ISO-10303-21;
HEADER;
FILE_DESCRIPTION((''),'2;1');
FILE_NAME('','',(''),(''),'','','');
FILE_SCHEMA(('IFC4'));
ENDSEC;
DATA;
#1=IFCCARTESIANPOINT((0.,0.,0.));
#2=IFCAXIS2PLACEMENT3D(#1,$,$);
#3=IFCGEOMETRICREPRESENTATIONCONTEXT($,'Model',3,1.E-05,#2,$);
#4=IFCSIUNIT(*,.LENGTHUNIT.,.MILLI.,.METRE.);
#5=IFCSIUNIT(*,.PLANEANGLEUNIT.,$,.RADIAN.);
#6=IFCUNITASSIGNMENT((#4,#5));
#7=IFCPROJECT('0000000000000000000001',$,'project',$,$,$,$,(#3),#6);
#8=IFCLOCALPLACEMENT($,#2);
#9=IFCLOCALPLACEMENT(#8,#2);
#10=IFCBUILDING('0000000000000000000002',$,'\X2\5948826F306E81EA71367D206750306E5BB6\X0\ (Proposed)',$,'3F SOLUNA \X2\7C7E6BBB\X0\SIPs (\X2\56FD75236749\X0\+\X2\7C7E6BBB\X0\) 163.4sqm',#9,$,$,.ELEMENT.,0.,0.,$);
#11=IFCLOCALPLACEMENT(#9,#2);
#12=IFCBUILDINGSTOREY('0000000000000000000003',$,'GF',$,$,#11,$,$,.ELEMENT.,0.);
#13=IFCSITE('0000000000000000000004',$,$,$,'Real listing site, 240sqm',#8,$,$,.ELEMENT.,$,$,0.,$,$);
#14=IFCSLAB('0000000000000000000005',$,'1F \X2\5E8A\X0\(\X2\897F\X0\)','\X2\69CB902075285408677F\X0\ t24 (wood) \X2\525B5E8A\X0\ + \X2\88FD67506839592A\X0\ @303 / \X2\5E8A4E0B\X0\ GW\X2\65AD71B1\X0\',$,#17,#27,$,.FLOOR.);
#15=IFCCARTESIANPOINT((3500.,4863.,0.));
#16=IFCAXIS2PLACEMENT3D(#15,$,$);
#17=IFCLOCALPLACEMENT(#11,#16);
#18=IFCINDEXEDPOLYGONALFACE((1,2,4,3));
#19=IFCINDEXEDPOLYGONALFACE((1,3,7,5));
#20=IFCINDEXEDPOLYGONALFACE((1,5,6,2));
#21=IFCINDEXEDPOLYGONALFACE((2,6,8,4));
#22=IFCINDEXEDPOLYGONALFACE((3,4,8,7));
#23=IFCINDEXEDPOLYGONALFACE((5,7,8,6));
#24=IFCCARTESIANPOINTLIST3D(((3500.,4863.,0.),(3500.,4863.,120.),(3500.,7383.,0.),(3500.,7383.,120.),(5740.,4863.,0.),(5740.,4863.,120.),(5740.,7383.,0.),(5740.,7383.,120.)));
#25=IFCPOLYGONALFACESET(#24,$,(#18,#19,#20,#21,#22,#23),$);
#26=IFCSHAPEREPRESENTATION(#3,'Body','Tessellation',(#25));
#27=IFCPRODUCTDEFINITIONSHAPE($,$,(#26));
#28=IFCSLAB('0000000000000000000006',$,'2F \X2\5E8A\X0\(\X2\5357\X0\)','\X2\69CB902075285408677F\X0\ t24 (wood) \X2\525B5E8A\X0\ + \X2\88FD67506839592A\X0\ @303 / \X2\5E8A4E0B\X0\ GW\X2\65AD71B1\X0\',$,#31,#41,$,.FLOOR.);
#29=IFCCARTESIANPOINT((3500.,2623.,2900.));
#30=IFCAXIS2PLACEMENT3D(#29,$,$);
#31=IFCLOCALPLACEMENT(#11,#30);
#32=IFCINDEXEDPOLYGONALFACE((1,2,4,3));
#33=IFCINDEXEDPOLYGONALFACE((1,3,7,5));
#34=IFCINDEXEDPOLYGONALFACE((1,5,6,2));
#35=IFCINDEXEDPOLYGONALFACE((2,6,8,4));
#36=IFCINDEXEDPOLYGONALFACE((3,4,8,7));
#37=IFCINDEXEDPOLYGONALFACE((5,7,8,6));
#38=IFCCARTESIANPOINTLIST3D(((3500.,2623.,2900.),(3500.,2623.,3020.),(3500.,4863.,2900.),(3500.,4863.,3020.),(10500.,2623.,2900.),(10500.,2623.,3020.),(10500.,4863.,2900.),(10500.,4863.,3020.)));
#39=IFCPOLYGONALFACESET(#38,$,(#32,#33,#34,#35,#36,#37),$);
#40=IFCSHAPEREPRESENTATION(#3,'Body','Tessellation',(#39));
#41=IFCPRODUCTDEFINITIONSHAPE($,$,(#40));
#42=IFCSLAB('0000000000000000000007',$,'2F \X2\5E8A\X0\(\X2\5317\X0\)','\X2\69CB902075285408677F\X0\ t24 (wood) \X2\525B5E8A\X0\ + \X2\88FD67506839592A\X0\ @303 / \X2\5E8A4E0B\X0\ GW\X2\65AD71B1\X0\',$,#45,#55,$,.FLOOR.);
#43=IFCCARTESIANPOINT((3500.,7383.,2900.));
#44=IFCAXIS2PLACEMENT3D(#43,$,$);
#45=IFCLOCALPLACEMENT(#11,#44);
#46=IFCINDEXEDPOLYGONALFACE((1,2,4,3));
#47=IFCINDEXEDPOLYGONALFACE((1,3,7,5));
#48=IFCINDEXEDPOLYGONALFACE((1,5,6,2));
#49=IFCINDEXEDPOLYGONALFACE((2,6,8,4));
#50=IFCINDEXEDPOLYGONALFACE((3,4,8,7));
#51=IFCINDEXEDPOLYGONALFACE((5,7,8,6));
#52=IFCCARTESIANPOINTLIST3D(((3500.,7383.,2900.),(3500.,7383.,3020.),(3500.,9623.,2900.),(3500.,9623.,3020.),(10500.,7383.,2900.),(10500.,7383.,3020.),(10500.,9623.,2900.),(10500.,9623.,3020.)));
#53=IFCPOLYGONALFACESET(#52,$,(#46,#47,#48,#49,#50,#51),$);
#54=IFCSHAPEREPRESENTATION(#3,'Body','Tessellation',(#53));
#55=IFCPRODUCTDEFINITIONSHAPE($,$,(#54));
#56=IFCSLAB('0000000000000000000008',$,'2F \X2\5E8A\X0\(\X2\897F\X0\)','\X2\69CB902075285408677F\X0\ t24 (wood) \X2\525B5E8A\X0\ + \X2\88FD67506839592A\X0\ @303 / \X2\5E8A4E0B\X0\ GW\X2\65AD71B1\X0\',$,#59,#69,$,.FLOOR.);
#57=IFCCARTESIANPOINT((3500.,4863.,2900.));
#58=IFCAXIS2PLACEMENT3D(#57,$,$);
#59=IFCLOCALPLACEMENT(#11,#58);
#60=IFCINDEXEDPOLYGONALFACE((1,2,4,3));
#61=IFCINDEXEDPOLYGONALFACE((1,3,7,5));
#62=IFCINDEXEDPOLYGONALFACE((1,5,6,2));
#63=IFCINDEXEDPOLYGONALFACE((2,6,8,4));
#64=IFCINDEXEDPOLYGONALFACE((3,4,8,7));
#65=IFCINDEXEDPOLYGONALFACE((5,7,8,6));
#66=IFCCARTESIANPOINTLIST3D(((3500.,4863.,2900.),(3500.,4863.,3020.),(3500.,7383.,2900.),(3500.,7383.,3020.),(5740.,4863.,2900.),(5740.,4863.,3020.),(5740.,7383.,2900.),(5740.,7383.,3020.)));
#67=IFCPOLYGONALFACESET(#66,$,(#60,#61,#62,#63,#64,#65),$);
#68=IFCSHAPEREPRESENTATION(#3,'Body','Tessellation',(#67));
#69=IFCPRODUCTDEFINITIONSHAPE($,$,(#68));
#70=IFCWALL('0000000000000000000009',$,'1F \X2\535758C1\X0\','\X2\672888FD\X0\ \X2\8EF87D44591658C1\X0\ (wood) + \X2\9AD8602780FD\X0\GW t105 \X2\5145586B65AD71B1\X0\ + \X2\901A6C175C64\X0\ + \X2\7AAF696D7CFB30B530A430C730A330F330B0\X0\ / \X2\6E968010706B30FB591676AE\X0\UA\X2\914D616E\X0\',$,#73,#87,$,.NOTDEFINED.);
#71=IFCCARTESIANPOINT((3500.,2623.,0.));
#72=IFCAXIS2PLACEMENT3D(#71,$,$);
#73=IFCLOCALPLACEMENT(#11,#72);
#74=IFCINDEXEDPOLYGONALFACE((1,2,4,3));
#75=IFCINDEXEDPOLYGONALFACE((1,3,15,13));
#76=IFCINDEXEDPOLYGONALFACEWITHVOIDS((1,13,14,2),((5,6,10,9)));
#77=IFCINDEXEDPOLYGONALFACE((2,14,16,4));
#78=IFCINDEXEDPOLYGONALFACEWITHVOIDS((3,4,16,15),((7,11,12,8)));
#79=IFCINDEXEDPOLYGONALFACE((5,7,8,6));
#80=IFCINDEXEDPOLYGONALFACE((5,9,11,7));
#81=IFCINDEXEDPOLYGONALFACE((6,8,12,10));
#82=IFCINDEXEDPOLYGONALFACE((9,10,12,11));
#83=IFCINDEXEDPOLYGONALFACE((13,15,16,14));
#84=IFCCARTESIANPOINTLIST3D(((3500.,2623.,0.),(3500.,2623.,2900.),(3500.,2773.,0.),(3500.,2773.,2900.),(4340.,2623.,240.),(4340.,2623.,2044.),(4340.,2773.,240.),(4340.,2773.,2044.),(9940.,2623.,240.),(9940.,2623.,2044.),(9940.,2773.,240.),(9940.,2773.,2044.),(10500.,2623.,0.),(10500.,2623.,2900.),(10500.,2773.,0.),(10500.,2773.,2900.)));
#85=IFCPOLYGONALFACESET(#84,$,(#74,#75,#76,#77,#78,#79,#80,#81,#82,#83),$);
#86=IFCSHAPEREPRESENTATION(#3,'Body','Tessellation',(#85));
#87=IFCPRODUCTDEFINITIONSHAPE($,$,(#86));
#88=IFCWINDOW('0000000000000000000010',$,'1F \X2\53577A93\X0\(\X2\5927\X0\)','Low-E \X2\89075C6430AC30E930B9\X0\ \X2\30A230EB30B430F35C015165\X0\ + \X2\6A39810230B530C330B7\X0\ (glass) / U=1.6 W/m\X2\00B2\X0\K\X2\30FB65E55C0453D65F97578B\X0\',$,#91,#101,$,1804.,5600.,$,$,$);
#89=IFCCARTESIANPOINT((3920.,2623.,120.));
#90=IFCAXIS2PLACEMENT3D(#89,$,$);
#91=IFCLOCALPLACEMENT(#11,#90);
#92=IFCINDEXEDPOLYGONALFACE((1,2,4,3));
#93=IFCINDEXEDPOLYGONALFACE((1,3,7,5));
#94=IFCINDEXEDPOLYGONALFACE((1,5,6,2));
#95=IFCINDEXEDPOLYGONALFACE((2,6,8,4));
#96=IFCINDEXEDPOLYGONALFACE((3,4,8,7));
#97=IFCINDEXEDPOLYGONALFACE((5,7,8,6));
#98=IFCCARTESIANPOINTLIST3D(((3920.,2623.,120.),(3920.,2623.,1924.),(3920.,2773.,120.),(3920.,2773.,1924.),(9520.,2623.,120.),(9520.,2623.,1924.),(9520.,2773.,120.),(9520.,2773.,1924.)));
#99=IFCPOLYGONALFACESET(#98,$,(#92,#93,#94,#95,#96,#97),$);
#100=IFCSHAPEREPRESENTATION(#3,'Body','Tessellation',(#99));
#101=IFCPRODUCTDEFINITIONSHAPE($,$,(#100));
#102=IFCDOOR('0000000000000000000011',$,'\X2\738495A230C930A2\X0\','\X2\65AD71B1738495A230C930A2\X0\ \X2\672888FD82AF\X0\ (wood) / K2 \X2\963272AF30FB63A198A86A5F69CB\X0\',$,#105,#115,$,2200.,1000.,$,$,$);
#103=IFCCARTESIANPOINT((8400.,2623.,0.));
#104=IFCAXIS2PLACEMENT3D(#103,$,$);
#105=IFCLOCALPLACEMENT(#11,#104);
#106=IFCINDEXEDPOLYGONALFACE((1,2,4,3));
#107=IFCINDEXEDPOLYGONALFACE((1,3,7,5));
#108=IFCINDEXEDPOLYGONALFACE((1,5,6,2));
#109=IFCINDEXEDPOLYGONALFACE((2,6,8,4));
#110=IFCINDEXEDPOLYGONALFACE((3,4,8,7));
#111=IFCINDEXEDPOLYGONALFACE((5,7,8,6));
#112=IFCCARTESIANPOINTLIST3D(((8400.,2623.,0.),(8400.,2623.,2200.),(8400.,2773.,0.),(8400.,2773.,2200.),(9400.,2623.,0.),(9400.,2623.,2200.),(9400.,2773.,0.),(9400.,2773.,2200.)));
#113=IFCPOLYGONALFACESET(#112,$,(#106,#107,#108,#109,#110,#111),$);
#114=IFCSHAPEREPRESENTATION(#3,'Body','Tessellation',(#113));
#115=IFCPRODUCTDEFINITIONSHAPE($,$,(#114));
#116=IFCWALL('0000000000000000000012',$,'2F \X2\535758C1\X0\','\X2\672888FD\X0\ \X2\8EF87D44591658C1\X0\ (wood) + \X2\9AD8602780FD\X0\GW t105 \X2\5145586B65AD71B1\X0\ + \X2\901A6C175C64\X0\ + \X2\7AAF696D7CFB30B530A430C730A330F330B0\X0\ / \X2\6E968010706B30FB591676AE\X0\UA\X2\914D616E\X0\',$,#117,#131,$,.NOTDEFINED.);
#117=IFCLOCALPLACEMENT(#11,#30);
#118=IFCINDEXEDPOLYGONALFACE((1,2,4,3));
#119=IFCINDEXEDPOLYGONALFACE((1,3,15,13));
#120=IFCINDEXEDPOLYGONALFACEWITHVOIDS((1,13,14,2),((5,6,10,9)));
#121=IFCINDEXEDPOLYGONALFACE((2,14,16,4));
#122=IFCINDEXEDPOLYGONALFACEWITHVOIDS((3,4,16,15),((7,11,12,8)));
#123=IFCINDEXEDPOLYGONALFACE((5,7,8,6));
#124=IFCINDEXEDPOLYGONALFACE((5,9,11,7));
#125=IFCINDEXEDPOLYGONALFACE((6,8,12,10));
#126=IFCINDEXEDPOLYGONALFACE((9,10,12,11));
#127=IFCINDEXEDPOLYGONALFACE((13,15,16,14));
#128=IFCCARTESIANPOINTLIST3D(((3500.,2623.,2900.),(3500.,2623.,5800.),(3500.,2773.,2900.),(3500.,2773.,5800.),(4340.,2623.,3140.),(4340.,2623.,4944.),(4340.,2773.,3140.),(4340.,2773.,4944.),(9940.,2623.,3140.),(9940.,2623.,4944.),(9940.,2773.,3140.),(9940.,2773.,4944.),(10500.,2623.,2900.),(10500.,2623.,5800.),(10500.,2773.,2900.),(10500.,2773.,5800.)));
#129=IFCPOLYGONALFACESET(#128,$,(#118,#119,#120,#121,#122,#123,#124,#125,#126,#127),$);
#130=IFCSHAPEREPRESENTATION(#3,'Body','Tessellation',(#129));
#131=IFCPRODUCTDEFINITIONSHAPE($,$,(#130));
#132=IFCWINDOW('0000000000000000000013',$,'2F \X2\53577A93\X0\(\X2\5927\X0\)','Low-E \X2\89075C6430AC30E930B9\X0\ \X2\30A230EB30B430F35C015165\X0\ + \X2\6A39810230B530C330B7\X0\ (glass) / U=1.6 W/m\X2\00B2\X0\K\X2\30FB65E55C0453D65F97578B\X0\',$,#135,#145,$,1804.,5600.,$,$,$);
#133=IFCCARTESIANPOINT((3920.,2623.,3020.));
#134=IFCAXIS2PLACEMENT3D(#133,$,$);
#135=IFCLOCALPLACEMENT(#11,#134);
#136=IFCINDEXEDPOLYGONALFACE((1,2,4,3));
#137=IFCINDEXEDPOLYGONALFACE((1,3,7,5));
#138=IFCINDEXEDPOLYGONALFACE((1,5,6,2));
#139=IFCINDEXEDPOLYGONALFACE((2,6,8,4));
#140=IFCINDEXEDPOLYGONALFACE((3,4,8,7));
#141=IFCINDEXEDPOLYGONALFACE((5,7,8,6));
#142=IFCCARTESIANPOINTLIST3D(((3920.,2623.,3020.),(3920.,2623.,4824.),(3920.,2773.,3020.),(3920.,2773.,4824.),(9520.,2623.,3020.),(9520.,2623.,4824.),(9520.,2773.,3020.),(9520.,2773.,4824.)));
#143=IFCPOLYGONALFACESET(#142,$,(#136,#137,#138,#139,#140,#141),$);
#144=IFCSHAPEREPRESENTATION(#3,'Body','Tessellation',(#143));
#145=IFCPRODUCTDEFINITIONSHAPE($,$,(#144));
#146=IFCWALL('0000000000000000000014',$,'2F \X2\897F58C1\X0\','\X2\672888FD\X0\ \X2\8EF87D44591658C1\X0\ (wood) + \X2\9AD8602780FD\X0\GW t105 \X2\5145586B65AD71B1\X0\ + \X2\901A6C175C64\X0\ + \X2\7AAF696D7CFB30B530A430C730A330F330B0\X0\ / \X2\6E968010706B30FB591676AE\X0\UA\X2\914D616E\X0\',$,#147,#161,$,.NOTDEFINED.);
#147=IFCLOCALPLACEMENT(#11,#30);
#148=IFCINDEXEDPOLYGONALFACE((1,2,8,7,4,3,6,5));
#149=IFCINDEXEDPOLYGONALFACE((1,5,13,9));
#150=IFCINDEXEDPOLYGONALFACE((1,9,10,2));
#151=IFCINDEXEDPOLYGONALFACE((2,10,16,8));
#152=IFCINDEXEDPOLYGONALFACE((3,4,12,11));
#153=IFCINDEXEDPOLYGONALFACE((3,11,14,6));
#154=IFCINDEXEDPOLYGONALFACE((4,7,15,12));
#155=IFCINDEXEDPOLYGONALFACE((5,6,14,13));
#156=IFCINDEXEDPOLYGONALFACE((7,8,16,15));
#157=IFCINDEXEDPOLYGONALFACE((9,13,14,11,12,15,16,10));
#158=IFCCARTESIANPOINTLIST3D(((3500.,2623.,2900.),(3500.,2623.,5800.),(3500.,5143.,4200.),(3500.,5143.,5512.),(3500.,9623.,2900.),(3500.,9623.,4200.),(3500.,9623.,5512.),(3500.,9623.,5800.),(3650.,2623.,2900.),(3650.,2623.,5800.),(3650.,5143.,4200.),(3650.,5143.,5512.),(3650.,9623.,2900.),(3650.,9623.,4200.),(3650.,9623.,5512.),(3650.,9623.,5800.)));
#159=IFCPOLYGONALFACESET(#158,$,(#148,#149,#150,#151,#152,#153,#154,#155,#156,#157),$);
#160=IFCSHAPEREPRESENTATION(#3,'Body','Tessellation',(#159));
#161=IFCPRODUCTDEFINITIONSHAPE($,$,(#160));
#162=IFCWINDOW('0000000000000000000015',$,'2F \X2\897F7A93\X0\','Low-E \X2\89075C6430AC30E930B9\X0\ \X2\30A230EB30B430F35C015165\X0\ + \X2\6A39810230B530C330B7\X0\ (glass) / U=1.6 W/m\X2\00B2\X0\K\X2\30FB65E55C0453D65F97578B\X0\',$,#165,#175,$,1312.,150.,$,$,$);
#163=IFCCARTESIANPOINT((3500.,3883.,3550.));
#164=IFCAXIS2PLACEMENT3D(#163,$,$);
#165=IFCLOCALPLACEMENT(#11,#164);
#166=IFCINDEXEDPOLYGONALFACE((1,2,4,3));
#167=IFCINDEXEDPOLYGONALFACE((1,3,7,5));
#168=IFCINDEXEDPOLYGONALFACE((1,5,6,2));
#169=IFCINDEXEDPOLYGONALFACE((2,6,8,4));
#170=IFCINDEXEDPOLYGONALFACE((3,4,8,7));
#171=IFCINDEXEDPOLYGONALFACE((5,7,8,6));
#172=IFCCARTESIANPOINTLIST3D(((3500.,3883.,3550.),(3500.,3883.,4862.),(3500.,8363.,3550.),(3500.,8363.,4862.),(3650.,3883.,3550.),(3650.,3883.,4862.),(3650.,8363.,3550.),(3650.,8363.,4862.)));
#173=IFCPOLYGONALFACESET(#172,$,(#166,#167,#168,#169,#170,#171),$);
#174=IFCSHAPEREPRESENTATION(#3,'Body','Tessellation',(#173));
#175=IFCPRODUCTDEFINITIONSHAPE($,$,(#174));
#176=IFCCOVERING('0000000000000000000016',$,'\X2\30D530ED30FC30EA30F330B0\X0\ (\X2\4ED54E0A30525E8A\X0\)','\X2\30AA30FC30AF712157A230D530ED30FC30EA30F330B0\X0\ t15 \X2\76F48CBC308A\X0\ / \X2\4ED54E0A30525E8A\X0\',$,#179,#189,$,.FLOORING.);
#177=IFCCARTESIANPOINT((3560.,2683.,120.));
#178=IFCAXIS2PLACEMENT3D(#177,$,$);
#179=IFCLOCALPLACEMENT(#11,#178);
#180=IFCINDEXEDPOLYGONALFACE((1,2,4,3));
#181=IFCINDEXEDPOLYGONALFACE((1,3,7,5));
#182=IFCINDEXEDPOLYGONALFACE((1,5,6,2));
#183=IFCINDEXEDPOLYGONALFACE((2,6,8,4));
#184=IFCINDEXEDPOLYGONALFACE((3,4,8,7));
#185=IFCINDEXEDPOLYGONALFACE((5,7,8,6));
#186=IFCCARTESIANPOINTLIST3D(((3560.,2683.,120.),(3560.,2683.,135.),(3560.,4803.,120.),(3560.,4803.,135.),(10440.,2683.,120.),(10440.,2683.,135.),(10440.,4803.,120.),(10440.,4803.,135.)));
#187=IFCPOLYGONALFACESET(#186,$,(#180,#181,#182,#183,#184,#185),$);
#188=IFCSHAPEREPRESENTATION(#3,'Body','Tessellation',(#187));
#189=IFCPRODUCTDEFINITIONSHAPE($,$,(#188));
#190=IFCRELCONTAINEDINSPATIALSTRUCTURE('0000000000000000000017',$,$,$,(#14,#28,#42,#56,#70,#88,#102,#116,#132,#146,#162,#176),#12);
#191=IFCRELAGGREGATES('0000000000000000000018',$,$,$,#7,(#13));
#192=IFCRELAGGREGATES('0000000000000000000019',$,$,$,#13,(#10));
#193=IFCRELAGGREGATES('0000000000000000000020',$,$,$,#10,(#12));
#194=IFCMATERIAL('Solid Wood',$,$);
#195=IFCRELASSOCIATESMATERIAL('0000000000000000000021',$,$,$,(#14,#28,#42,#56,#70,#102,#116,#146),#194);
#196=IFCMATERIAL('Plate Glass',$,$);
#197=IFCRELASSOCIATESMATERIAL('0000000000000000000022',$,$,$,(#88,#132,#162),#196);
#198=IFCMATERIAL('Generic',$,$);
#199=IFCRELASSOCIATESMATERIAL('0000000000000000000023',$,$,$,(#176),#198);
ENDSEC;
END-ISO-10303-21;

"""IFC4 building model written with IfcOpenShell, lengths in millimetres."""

from ifc_helpers import new_model, si_unit, frame, frame_2d, origin, place, context, project, spatial, rectangle, extrude, material, element, fill, save


model = new_model("IFC4")

# Units and contexts
model_context = context("Model", 3, precision=1e-05, world=origin())
ifc_project = project(units=[si_unit("LENGTHUNIT", "METRE", prefix="MILLI"), si_unit("PLANEANGLEUNIT", "RADIAN")], contexts=[model_context])

# Site, building, storey
site_placement = place(None, origin())
site = spatial("IfcSite", under=ifc_project, at=site_placement, ObjectType="Real listing site, 240sqm", CompositionType="ELEMENT", RefElevation=0.0)
building_placement = place(site_placement, origin())
building = spatial("IfcBuilding", under=site, at=building_placement, Name="奈良の自然素材の家 (Proposed)", ObjectType="3F SOLUNA 籾殻SIPs (国産杉+籾殻) 163.4sqm", CompositionType="ELEMENT", ElevationOfRefHeight=0.0, ElevationOfTerrain=0.0)
storey_placement = place(building_placement, origin())
storey = spatial("IfcBuildingStorey", under=building, at=storey_placement, Name="GF", CompositionType="ELEMENT", Elevation=0.0)

# Slabs
ifc_material_1 = material(Name="Solid Wood")
slab_1_placement = place(storey_placement, frame((3500.0, 4863.0, 0.0)))
element("IfcSlab", 1, at=slab_1_placement, inside=storey, material=ifc_material_1, Name="1F 床(西)", Description="構造用合板 t24 (wood) 剛床 + 製材根太 @303 / 床下 GW断熱", PredefinedType="FLOOR", context=model_context, shape_type="SweptSolid", body=[
    extrude(rectangle(XDim=2240.0, YDim=2520.0, at=frame_2d((1120.0, 1260.0))), frame((3500.0, 4863.0, 0.0)), (0.0, 0.0, 1.0), 120.0),
])
slab_2_placement = place(storey_placement, frame((3500.0, 2623.0, 2900.0)))
element("IfcSlab", 2, at=slab_2_placement, inside=storey, material=ifc_material_1, Name="2F 床(南)", Description="構造用合板 t24 (wood) 剛床 + 製材根太 @303 / 床下 GW断熱", PredefinedType="FLOOR", context=model_context, shape_type="SweptSolid", body=[
    extrude(rectangle(XDim=7000.0, YDim=2240.0, at=frame_2d((3500.0, 1120.0))), frame((3500.0, 2623.0, 2900.0)), (0.0, 0.0, 1.0), 120.0),
])
slab_3_placement = place(storey_placement, frame((3500.0, 7383.0, 2900.0)))
element("IfcSlab", 3, at=slab_3_placement, inside=storey, material=ifc_material_1, Name="2F 床(北)", Description="構造用合板 t24 (wood) 剛床 + 製材根太 @303 / 床下 GW断熱", PredefinedType="FLOOR", context=model_context, shape_type="SweptSolid", body=[
    extrude(rectangle(XDim=7000.0, YDim=2240.0, at=frame_2d((3500.0, 1120.0))), frame((3500.0, 7383.0, 2900.0)), (0.0, 0.0, 1.0), 120.0),
])
slab_4_placement = place(storey_placement, frame((3500.0, 4863.0, 2900.0)))
element("IfcSlab", 4, at=slab_4_placement, inside=storey, material=ifc_material_1, Name="2F 床(西)", Description="構造用合板 t24 (wood) 剛床 + 製材根太 @303 / 床下 GW断熱", PredefinedType="FLOOR", context=model_context, shape_type="SweptSolid", body=[
    extrude(rectangle(XDim=2240.0, YDim=2520.0, at=frame_2d((1120.0, 1260.0))), frame((3500.0, 4863.0, 2900.0)), (0.0, 0.0, 1.0), 120.0),
])

# Wall, openings, window, door
wall_1_placement = place(storey_placement, frame((3500.0, 2623.0, 0.0)))
wall_1 = element("IfcWall", 5, at=wall_1_placement, inside=storey, material=ifc_material_1, Name="1F 南壁", Description="木製 軸組外壁 (wood) + 高性能GW t105 充填断熱 + 通気層 + 窯業系サイディング / 準耐火・外皮UA配慮", PredefinedType="NOTDEFINED", context=model_context, shape_type="SweptSolid", body=[
    extrude(rectangle(XDim=7000.0, YDim=150.0, at=frame_2d((3500.0, 75.0))), frame((3500.0, 2623.0, 0.0)), (0.0, 0.0, 1.0), 2900.0),
])
opening_1_placement = place(storey_placement, frame((3920.0, 2623.0, 120.0)))
opening_1 = element("IfcOpeningElement", 6, at=opening_1_placement, cuts=wall_1, PredefinedType="NOTDEFINED", context=model_context, shape_type="SweptSolid", body=[
    extrude(rectangle(XDim=5600.0, YDim=150.0, at=frame_2d((2800.0, 75.0))), frame((3920.0, 2623.0, 120.0)), (0.0, 0.0, 1.0), 1804.0),
])
opening_2_placement = place(storey_placement, frame((8400.0, 2623.0, 0.0)))
opening_2 = element("IfcOpeningElement", 7, at=opening_2_placement, cuts=wall_1, PredefinedType="NOTDEFINED", context=model_context, shape_type="SweptSolid", body=[
    extrude(rectangle(XDim=1000.0, YDim=150.0, at=frame_2d((500.0, 75.0))), frame((8400.0, 2623.0, 0.0)), (0.0, 0.0, 1.0), 2200.0),
])
ifc_material_2 = material(Name="Plate Glass")
window_1_placement = place(storey_placement, frame((3920.0, 2623.0, 120.0)))
window_1 = element("IfcWindow", 8, at=window_1_placement, inside=storey, material=ifc_material_2, Name="1F 南窓(大)", Description="Low-E 複層ガラス アルゴン封入 + 樹脂サッシ (glass) / U=1.6 W/m²K・日射取得型", OverallHeight=1804.0, OverallWidth=5600.0, context=model_context, shape_type="SweptSolid", body=[
    extrude(rectangle(XDim=5600.0, YDim=150.0, at=frame_2d((2800.0, 75.0))), frame((3920.0, 2623.0, 120.0)), (0.0, 0.0, 1.0), 1804.0),
])
fill(opening_1, window_1)
door_placement = place(storey_placement, frame((8400.0, 2623.0, 0.0)))
door = element("IfcDoor", 9, at=door_placement, inside=storey, material=ifc_material_1, Name="玄関ドア", Description="断熱玄関ドア 木製芯 (wood) / K2 防犯・採風機構", OverallHeight=2200.0, OverallWidth=1000.0, context=model_context, shape_type="SweptSolid", body=[
    extrude(rectangle(XDim=1000.0, YDim=150.0, at=frame_2d((500.0, 75.0))), frame((8400.0, 2623.0, 0.0)), (0.0, 0.0, 1.0), 2200.0),
])
fill(opening_2, door)

# Wall, opening, window
wall_2_placement = place(storey_placement, frame((3500.0, 2623.0, 2900.0)))
wall_2 = element("IfcWall", 10, at=wall_2_placement, inside=storey, material=ifc_material_1, Name="2F 南壁", Description="木製 軸組外壁 (wood) + 高性能GW t105 充填断熱 + 通気層 + 窯業系サイディング / 準耐火・外皮UA配慮", PredefinedType="NOTDEFINED", context=model_context, shape_type="SweptSolid", body=[
    extrude(rectangle(XDim=7000.0, YDim=150.0, at=frame_2d((3500.0, 75.0))), frame((3500.0, 2623.0, 2900.0)), (0.0, 0.0, 1.0), 2900.0),
])
opening_3_placement = place(storey_placement, frame((3920.0, 2623.0, 3020.0)))
opening_3 = element("IfcOpeningElement", 11, at=opening_3_placement, cuts=wall_2, PredefinedType="NOTDEFINED", context=model_context, shape_type="SweptSolid", body=[
    extrude(rectangle(XDim=5600.0, YDim=150.0, at=frame_2d((2800.0, 75.0))), frame((3920.0, 2623.0, 3020.0)), (0.0, 0.0, 1.0), 1804.0),
])
window_2_placement = place(storey_placement, frame((3920.0, 2623.0, 3020.0)))
window_2 = element("IfcWindow", 12, at=window_2_placement, inside=storey, material=ifc_material_2, Name="2F 南窓(大)", Description="Low-E 複層ガラス アルゴン封入 + 樹脂サッシ (glass) / U=1.6 W/m²K・日射取得型", OverallHeight=1804.0, OverallWidth=5600.0, context=model_context, shape_type="SweptSolid", body=[
    extrude(rectangle(XDim=5600.0, YDim=150.0, at=frame_2d((2800.0, 75.0))), frame((3920.0, 2623.0, 3020.0)), (0.0, 0.0, 1.0), 1804.0),
])
fill(opening_3, window_2)

# Wall, opening, window
wall_3_placement = place(storey_placement, frame((3500.0, 2623.0, 2900.0)))
wall_3 = element("IfcWall", 13, at=wall_3_placement, inside=storey, material=ifc_material_1, Name="2F 西壁", Description="木製 軸組外壁 (wood) + 高性能GW t105 充填断熱 + 通気層 + 窯業系サイディング / 準耐火・外皮UA配慮", PredefinedType="NOTDEFINED", context=model_context, shape_type="SweptSolid", body=[
    extrude(rectangle(XDim=150.0, YDim=7000.0, at=frame_2d((75.0, 3500.0))), frame((3500.0, 2623.0, 2900.0)), (0.0, 0.0, 1.0), 2900.0),
])
opening_4_placement = place(storey_placement, frame((3500.0, 3883.0, 3550.0)))
opening_4 = element("IfcOpeningElement", 14, at=opening_4_placement, cuts=wall_3, PredefinedType="NOTDEFINED", context=model_context, shape_type="SweptSolid", body=[
    extrude(rectangle(XDim=150.0, YDim=4480.0, at=frame_2d((75.0, 2240.0))), frame((3500.0, 3883.0, 3550.0)), (0.0, 0.0, 1.0), 1312.0),
])
window_3_placement = place(storey_placement, frame((3500.0, 3883.0, 3550.0)))
window_3 = element("IfcWindow", 15, at=window_3_placement, inside=storey, material=ifc_material_2, Name="2F 西窓", Description="Low-E 複層ガラス アルゴン封入 + 樹脂サッシ (glass) / U=1.6 W/m²K・日射取得型", OverallHeight=1312.0, OverallWidth=150.0, context=model_context, shape_type="SweptSolid", body=[
    extrude(rectangle(XDim=150.0, YDim=4480.0, at=frame_2d((75.0, 2240.0))), frame((3500.0, 3883.0, 3550.0)), (0.0, 0.0, 1.0), 1312.0),
])
fill(opening_4, window_3)

# Covering
ifc_material_3 = material(Name="Generic")
covering_1_placement = place(storey_placement, frame((3560.0, 2683.0, 120.0)))
element("IfcCovering", 16, at=covering_1_placement, inside=storey, material=ifc_material_3, Name="フローリング (仕上げ床)", Description="オーク無垢フローリング t15 直貼り / 仕上げ床", PredefinedType="FLOORING", context=model_context, shape_type="SweptSolid", body=[
    extrude(rectangle(XDim=6880.0, YDim=2120.0, at=frame_2d((3440.0, 1060.0))), frame((3560.0, 2683.0, 120.0)), (0.0, 0.0, 1.0), 15.0),
])

save(model, "model.ifc")
